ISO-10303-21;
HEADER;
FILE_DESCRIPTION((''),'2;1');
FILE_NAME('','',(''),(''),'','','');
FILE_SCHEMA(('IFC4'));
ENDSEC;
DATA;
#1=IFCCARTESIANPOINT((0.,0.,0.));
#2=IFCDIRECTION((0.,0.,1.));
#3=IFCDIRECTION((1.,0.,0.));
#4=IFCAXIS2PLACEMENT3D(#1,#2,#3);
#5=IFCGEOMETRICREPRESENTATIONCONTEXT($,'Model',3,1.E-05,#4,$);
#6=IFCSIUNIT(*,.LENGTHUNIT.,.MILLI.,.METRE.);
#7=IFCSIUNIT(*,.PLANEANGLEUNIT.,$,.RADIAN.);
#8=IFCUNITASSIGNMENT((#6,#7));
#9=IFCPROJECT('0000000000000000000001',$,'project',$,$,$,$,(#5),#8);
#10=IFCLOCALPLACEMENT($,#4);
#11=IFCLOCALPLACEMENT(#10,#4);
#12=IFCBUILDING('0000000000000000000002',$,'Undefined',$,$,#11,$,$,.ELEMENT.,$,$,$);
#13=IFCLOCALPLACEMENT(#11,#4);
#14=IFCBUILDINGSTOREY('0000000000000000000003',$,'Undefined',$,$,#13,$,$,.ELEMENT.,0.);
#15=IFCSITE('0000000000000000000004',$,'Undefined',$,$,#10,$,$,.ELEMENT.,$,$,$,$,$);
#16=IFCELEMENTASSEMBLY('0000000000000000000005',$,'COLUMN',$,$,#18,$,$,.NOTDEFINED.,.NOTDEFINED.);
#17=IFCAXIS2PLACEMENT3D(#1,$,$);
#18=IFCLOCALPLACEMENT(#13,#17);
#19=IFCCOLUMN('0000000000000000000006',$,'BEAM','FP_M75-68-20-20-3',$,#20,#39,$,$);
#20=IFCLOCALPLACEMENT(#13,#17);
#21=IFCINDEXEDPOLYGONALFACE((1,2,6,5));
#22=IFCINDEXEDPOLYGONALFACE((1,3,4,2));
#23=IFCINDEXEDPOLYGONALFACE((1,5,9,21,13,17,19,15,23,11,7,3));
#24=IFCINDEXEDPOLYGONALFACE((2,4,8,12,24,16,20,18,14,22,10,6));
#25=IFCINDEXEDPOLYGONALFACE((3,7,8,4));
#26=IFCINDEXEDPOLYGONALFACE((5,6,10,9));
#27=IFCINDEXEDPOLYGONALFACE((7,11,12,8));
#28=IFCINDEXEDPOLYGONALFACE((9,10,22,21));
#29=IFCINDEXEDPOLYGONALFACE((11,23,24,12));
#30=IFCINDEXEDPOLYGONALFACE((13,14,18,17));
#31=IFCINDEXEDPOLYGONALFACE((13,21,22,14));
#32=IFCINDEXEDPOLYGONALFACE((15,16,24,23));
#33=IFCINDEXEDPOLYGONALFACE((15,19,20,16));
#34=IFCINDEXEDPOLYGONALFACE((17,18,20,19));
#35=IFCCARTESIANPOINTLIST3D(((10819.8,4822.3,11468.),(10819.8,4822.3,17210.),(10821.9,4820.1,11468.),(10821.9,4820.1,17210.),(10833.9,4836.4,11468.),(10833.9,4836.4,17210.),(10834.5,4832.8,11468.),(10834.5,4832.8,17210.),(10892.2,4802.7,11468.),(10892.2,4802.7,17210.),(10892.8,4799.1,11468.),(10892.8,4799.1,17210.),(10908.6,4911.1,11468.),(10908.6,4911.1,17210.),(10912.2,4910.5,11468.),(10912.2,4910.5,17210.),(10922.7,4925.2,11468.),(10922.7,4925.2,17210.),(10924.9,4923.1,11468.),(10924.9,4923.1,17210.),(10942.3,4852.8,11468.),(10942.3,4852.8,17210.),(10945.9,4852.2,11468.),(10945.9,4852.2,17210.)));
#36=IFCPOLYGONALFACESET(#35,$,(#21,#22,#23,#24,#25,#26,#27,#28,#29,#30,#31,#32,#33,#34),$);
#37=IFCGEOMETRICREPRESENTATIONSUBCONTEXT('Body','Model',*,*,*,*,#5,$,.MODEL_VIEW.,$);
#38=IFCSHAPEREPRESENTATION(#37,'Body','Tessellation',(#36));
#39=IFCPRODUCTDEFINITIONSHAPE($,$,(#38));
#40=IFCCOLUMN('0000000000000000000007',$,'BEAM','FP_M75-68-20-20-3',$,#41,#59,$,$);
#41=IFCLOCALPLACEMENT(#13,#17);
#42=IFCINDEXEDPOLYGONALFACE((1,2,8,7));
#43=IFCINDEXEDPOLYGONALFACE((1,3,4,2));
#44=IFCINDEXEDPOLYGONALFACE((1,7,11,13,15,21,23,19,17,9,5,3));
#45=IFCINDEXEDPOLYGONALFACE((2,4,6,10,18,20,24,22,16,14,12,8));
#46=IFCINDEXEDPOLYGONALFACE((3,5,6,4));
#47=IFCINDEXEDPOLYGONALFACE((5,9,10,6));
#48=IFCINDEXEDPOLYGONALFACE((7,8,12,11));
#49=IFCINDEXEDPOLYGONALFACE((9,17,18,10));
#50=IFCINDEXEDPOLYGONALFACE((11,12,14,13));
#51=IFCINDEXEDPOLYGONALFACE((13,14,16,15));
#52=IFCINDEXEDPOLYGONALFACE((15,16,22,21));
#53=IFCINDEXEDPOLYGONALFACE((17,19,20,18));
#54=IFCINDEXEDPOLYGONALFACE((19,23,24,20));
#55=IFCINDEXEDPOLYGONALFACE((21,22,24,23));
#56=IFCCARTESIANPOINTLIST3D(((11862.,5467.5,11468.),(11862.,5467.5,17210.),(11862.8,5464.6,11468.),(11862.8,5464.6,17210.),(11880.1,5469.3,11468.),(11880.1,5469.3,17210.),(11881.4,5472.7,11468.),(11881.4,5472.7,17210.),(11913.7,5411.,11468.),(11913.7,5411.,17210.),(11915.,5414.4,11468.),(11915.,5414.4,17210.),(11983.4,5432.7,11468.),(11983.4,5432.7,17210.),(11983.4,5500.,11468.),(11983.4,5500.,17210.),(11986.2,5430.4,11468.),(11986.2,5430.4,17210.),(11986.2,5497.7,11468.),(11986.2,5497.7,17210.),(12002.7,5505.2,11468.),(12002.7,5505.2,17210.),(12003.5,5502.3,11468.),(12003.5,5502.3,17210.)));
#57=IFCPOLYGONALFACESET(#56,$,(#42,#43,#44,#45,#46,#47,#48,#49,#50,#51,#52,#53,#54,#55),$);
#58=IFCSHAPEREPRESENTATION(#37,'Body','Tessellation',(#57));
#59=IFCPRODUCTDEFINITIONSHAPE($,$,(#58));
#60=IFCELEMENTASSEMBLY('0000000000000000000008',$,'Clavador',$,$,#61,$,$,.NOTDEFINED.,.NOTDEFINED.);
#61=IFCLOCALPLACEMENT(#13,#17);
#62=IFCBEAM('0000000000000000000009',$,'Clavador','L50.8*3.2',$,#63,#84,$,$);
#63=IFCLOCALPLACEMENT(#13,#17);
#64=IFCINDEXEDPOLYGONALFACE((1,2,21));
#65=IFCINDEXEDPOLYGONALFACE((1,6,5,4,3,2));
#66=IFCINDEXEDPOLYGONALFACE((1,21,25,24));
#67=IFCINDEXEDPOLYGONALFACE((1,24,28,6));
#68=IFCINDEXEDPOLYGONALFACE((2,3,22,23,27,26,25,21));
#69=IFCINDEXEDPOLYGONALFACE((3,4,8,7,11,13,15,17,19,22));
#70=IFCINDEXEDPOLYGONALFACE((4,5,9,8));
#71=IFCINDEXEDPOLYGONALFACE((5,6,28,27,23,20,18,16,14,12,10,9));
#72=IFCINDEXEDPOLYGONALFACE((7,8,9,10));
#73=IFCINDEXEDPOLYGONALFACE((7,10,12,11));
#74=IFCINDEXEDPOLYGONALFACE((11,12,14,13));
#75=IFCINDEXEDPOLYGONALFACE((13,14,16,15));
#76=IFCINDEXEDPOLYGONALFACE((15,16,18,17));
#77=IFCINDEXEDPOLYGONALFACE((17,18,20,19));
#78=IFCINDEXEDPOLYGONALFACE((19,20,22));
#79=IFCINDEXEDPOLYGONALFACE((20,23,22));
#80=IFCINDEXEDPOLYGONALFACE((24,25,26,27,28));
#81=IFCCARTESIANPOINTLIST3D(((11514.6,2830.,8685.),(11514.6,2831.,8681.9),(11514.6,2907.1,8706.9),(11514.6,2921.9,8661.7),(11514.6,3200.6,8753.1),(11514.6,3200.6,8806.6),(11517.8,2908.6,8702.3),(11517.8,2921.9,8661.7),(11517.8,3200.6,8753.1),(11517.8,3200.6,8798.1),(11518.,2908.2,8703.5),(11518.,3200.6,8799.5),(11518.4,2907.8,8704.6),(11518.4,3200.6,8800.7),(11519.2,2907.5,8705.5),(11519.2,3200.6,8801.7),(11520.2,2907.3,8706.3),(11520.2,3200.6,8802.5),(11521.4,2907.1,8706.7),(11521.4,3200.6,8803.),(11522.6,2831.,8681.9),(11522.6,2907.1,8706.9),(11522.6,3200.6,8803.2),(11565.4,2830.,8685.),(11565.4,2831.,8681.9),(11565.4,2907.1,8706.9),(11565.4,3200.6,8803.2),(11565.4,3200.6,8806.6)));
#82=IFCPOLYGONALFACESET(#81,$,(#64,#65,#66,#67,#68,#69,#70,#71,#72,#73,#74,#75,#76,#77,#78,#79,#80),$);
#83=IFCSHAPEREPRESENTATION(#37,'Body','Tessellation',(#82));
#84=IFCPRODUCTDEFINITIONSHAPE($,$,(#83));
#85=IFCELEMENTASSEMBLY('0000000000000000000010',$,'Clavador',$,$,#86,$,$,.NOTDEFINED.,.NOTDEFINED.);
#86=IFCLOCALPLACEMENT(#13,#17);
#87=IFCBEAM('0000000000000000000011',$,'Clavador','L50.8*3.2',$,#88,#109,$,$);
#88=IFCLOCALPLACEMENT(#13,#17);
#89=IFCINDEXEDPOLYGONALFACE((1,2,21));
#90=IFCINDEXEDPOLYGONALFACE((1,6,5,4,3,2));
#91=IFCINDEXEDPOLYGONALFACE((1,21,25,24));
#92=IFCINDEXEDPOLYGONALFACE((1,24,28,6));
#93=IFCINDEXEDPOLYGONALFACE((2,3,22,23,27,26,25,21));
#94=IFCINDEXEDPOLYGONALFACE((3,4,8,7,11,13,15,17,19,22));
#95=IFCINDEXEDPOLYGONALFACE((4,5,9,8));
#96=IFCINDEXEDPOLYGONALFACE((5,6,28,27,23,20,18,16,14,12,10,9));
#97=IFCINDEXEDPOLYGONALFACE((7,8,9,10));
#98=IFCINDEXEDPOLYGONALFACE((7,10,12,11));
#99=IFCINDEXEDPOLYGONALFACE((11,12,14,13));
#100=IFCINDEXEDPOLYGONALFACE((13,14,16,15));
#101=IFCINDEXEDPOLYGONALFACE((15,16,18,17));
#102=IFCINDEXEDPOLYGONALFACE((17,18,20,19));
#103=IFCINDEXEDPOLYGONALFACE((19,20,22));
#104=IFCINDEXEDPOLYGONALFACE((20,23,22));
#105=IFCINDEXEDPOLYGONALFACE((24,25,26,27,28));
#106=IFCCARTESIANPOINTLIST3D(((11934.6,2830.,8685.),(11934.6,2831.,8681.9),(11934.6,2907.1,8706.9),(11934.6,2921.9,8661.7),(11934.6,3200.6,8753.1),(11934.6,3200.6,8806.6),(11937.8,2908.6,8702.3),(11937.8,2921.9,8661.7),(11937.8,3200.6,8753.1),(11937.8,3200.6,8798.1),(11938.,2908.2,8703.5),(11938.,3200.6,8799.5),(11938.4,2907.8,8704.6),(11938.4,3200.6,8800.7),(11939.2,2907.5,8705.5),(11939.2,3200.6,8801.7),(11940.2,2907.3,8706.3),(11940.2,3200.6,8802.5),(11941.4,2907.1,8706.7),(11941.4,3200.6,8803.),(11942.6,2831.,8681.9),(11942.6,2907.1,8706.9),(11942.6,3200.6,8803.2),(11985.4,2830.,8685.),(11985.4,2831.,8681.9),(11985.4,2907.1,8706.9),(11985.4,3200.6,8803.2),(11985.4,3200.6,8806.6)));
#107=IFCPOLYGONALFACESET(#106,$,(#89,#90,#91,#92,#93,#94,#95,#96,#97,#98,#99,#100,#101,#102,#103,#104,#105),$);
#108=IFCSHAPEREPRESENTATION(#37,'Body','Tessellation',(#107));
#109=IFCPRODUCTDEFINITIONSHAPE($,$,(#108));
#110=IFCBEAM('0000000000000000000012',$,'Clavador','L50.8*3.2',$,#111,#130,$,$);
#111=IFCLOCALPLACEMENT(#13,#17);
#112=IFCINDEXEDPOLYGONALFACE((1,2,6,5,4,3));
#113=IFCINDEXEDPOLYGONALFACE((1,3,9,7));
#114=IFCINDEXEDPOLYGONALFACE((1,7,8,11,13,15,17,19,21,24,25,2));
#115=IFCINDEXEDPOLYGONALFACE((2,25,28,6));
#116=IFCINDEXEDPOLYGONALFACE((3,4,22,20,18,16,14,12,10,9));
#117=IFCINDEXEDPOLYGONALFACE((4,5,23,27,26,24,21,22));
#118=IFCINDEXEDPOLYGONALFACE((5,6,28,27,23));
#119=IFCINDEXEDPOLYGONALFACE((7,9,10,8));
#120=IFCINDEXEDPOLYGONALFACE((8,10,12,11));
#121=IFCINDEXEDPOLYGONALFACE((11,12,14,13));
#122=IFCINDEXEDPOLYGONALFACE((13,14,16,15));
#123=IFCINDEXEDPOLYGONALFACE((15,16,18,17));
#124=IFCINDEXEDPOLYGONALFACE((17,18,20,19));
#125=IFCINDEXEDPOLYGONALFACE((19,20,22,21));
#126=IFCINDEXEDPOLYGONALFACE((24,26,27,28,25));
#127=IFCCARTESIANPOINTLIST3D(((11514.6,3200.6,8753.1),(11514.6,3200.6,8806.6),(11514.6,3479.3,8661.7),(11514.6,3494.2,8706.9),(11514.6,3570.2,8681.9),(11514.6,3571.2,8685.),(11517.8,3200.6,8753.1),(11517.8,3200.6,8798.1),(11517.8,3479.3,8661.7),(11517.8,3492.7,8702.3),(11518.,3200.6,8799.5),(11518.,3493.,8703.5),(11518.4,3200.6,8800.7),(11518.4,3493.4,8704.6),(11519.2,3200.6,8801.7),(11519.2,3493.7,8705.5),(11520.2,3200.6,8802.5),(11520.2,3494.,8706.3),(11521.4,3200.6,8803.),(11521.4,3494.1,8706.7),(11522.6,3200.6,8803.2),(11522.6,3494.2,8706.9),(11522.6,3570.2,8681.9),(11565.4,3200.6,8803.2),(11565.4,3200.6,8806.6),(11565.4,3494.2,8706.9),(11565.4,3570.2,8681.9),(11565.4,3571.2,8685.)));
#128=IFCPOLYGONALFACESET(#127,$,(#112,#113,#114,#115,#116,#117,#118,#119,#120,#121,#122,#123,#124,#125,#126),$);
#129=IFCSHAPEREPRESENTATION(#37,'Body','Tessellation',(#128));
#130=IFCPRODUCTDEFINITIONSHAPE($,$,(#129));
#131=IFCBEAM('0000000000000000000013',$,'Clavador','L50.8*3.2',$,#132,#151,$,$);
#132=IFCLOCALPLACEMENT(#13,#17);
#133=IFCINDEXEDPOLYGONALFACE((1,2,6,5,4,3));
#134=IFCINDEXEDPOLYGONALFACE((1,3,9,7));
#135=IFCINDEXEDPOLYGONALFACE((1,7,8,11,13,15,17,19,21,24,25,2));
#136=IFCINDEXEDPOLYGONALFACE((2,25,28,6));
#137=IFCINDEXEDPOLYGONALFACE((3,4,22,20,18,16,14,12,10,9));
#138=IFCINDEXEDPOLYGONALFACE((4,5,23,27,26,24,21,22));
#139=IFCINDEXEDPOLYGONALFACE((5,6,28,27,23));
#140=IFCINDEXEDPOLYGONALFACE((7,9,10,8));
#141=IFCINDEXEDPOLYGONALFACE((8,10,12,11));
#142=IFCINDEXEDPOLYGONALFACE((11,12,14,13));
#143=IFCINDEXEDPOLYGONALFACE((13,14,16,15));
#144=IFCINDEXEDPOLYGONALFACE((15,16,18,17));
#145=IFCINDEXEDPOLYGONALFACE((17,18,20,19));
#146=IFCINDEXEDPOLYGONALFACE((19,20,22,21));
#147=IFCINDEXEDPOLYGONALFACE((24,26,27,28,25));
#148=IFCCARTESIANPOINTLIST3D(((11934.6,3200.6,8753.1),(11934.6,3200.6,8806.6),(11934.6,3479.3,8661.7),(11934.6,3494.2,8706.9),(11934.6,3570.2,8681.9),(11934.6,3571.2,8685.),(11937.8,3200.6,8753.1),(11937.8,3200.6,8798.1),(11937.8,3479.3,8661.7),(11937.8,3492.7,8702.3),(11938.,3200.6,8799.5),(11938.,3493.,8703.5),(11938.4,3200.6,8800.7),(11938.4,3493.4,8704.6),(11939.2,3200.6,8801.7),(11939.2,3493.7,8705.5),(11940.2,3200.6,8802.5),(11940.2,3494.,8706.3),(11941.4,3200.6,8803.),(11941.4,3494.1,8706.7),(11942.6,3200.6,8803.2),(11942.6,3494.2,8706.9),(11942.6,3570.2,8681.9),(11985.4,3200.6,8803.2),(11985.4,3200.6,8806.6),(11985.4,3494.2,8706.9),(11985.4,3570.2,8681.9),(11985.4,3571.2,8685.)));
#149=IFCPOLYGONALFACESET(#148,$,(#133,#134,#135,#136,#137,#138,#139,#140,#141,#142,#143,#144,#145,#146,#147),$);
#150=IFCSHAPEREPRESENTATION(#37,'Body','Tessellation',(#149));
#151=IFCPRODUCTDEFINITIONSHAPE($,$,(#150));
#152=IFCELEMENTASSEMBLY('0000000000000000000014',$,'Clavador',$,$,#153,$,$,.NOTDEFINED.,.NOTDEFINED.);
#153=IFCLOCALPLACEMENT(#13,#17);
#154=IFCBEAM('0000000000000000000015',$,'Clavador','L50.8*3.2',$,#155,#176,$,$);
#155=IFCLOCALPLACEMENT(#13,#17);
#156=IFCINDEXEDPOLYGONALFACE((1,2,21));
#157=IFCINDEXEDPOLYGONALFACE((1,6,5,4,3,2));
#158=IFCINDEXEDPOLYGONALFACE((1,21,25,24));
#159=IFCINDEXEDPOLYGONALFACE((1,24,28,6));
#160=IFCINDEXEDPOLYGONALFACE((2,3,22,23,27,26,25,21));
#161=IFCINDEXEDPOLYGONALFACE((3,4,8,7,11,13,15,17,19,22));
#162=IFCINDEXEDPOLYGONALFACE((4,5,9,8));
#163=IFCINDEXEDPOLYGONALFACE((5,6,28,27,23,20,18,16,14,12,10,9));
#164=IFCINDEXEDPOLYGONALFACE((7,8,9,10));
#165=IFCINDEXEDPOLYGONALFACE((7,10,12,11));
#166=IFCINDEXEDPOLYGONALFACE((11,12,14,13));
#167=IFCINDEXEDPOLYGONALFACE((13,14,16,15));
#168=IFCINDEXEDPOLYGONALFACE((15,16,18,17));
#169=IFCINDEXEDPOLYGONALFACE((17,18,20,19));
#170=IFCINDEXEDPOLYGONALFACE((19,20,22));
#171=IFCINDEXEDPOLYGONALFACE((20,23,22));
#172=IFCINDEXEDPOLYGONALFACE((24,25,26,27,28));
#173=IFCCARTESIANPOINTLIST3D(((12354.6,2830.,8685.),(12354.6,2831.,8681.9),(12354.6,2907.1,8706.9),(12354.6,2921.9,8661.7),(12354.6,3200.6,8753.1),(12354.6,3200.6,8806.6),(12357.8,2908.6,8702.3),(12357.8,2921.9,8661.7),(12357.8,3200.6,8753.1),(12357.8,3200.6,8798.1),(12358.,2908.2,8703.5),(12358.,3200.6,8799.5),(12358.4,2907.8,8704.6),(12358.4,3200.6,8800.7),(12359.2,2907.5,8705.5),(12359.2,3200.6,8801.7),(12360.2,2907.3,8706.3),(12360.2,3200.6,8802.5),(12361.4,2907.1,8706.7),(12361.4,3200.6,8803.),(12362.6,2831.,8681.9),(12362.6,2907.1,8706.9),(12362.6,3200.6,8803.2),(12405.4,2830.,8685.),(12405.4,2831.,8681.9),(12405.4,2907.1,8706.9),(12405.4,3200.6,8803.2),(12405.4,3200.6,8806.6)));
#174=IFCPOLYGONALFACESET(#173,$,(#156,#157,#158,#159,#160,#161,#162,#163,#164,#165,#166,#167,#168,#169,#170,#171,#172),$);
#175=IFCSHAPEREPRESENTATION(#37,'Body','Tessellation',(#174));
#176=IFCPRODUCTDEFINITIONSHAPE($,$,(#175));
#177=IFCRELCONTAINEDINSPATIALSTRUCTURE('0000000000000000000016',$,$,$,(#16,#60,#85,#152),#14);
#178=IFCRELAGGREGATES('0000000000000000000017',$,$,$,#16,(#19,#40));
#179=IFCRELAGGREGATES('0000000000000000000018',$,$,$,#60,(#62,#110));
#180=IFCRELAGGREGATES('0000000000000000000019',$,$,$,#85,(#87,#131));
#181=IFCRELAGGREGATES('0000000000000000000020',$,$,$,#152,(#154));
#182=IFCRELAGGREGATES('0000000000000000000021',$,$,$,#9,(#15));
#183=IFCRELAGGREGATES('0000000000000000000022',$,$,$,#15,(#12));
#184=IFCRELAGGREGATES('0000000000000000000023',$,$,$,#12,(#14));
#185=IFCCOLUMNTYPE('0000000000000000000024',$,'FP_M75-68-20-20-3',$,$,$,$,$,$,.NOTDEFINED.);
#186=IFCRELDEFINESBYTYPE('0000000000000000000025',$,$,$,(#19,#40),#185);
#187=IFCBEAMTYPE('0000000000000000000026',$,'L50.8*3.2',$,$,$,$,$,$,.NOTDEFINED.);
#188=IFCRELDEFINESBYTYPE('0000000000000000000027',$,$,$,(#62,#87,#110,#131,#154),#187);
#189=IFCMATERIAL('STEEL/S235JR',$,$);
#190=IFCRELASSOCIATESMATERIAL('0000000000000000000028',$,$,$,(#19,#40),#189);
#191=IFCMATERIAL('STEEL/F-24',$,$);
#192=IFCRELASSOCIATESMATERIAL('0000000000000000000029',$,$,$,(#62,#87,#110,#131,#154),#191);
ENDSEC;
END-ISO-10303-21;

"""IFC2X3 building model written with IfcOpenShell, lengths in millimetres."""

from ifc_helpers import new_model, si_unit, frame, origin_with_axes, origin_2d_with_axis, place, context, subcontext, project, spatial, polyline, l_section, outline, extrude, boolean, halfspace, material, type_object, element, aggregate, save


model = new_model("IFC2X3")

# Units and contexts
model_context = context("Model", 3, precision=1e-05, world=origin_with_axes())
body_context = subcontext(model_context, "Body", "Model", "MODEL_VIEW")
ifc_project = project(units=[si_unit("LENGTHUNIT", "METRE", prefix="MILLI"), si_unit("PLANEANGLEUNIT", "RADIAN")], contexts=[model_context])

# Site, building, storey
site_placement = place(None, origin_with_axes())
site = spatial("IfcSite", under=ifc_project, at=site_placement, Name="Undefined", CompositionType="ELEMENT")
building_placement = place(site_placement, origin_with_axes())
building = spatial("IfcBuilding", under=site, at=building_placement, Name="Undefined", CompositionType="ELEMENT")
storey_placement = place(building_placement, origin_with_axes())
storey = spatial("IfcBuildingStorey", under=building, at=storey_placement, Name="Undefined", CompositionType="ELEMENT", Elevation=0.0)

# Element assembly, columns
assembly_1_placement = place(storey_placement, origin_with_axes())
assembly_1 = element("IfcElementAssembly", 1, at=assembly_1_placement, inside=storey, Name="COLUMN", AssemblyPlace="NOTDEFINED", PredefinedType="NOTDEFINED")
ifc_material_1 = material(Name="STEEL/S235JR")
column_type = type_object("IfcColumnType", Name="FP_M75-68-20-20-3", PredefinedType="NOTDEFINED")
column_1_placement = place(assembly_1_placement, frame((10895.3, 4849.7, 11468.0), z_axis=(0.0, 0.0, 1.0), x_axis=(0.707107, 0.707107, 0.0)))
column_1 = element("IfcColumn", 2, at=column_1_placement, type_object=column_type, material=ifc_material_1, Name="BEAM", Description="FP_M75-68-20-20-3", context=body_context, shape_type="SweptSolid", body=[
    extrude(outline(polyline([(31.0, 54.9), (31.0, 72.8), (34.0, 72.8), (34.0, 52.8), (-31.0, 35.4), (-31.0, -35.4), (34.0, -52.8), (34.0, -72.8), (31.0, -72.8), (31.0, -54.9), (-34.0, -37.5), (-34.0, 37.5), (31.0, 54.9)])), frame((0.0, 0.0, 5742.0), z_axis=(0.0, 0.0, -1.0), x_axis=(0.0, 1.0, 0.0)), (0.0, 0.0, 1.0), 5742.0),
])
column_2_placement = place(assembly_1_placement, frame((11941.2, 5453.5, 11468.0), z_axis=(0.0, 0.0, 1.0), x_axis=(0.965926, 0.258819, 0.0)))
column_2 = element("IfcColumn", 3, at=column_2_placement, type_object=column_type, material=ifc_material_1, Name="BEAM", Description="FP_M75-68-20-20-3", context=body_context, shape_type="SweptSolid", body=[
    extrude(outline(polyline([(31.0, 54.9), (31.0, 72.8), (34.0, 72.8), (34.0, 52.8), (-31.0, 35.4), (-31.0, -35.4), (34.0, -52.8), (34.0, -72.8), (31.0, -72.8), (31.0, -54.9), (-34.0, -37.5), (-34.0, 37.5), (31.0, 54.9)])), frame((0.0, 0.0, 5742.0), z_axis=(0.0, 0.0, -1.0), x_axis=(0.0, 1.0, 0.0)), (0.0, 0.0, 1.0), 5742.0),
])
aggregate(assembly_1, [column_1, column_2])

# Element assemblies, beams
assembly_2_placement = place(storey_placement, origin_with_axes())
assembly_2 = element("IfcElementAssembly", 4, at=assembly_2_placement, inside=storey, Name="Clavador", AssemblyPlace="NOTDEFINED", PredefinedType="NOTDEFINED")
ifc_material_2 = material(Name="STEEL/F-24")
beam_type_1 = type_object("IfcBeamType", Name="L50.8*3.2", PredefinedType="NOTDEFINED")
beam_1_placement = place(assembly_2_placement, frame((11540.0, 3208.5, 8782.4), z_axis=(0.0, 0.311771, -0.950157), x_axis=(0.0, -0.950157, -0.311771)))
beam_1 = element("IfcBeam", 5, at=beam_1_placement, type_object=beam_type_1, material=ifc_material_2, Name="Clavador", Description="L50.8*3.2", context=body_context, shape_type="CSG", body=[
    boolean("DIFFERENCE", boolean("DIFFERENCE", extrude(l_section(Depth=50.8, Width=50.8, Thickness=3.2, FilletRadius=4.8, at=origin_2d_with_axis()), frame((390.0, 0.0, 0.0), z_axis=(-1.0, 0.0, 0.0), x_axis=(0.0, -1.0, 0.0)), (0.0, 0.0, 1.0), 397.4), extrude(outline(polyline([(0.0, 0.0), (47.6, 0.0), (47.6, 80.0), (0.0, 80.0), (0.0, 0.0)])), frame((390.0, 28.0, -22.2), z_axis=(0.0, -1.0, 0.0), x_axis=(0.0, 0.0, 1.0)), (0.0, 0.0, 1.0), 56.0)), halfspace(frame((0.0, 0.0, -25.4), z_axis=(-0.950157, 0.0, 0.311771), x_axis=(0.0, 1.0, 0.0)), False)),
])
assembly_3_placement = place(storey_placement, origin_with_axes())
assembly_3 = element("IfcElementAssembly", 6, at=assembly_3_placement, inside=storey, Name="Clavador", AssemblyPlace="NOTDEFINED", PredefinedType="NOTDEFINED")
beam_2_placement = place(assembly_3_placement, frame((11960.0, 3208.5, 8782.4), z_axis=(0.0, 0.311771, -0.950157), x_axis=(0.0, -0.950157, -0.311771)))
beam_2 = element("IfcBeam", 7, at=beam_2_placement, type_object=beam_type_1, material=ifc_material_2, Name="Clavador", Description="L50.8*3.2", context=body_context, shape_type="CSG", body=[
    boolean("DIFFERENCE", boolean("DIFFERENCE", extrude(l_section(Depth=50.8, Width=50.8, Thickness=3.2, FilletRadius=4.8, at=origin_2d_with_axis()), frame((390.0, 0.0, 0.0), z_axis=(-1.0, 0.0, 0.0), x_axis=(0.0, -1.0, 0.0)), (0.0, 0.0, 1.0), 397.4), extrude(outline(polyline([(0.0, 0.0), (47.6, 0.0), (47.6, 80.0), (0.0, 80.0), (0.0, 0.0)])), frame((390.0, 28.0, -22.2), z_axis=(0.0, -1.0, 0.0), x_axis=(0.0, 0.0, 1.0)), (0.0, 0.0, 1.0), 56.0)), halfspace(frame((0.0, 0.0, -25.4), z_axis=(-0.950157, 0.0, 0.311771), x_axis=(0.0, 1.0, 0.0)), False)),
])

# Beams
beam_3_placement = place(assembly_2_placement, frame((11540.0, 3563.2, 8660.8), z_axis=(0.0, -0.311771, -0.950157), x_axis=(0.0, -0.950157, 0.311771)))
beam_3 = element("IfcBeam", 8, at=beam_3_placement, type_object=beam_type_1, material=ifc_material_2, Name="Clavador", Description="L50.8*3.2", context=body_context, shape_type="CSG", body=[
    boolean("DIFFERENCE", boolean("DIFFERENCE", extrude(l_section(Depth=50.8, Width=50.8, Thickness=3.2, FilletRadius=4.8, at=origin_2d_with_axis()), frame((397.4, 0.0, 0.0), z_axis=(-1.0, 0.0, 0.0), x_axis=(0.0, -1.0, 0.0)), (0.0, 0.0, 1.0), 397.4), extrude(outline(polyline([(0.0, 0.0), (47.6, 0.0), (47.6, 80.0), (0.0, 80.0), (0.0, 0.0)])), frame((0.0, -28.0, -22.2), z_axis=(0.0, 1.0, 0.0), x_axis=(0.0, 0.0, 1.0)), (0.0, 0.0, 1.0), 56.0)), halfspace(frame((390.0, 0.0, -25.4), z_axis=(-0.950157, 0.0, -0.311771), x_axis=(0.0, 1.0, 0.0)), True)),
])
aggregate(assembly_2, [beam_1, beam_3])
beam_4_placement = place(assembly_3_placement, frame((11960.0, 3563.2, 8660.8), z_axis=(0.0, -0.311771, -0.950157), x_axis=(0.0, -0.950157, 0.311771)))
beam_4 = element("IfcBeam", 9, at=beam_4_placement, type_object=beam_type_1, material=ifc_material_2, Name="Clavador", Description="L50.8*3.2", context=body_context, shape_type="CSG", body=[
    boolean("DIFFERENCE", boolean("DIFFERENCE", extrude(l_section(Depth=50.8, Width=50.8, Thickness=3.2, FilletRadius=4.8, at=origin_2d_with_axis()), frame((397.4, 0.0, 0.0), z_axis=(-1.0, 0.0, 0.0), x_axis=(0.0, -1.0, 0.0)), (0.0, 0.0, 1.0), 397.4), extrude(outline(polyline([(0.0, 0.0), (47.6, 0.0), (47.6, 80.0), (0.0, 80.0), (0.0, 0.0)])), frame((0.0, -28.0, -22.2), z_axis=(0.0, 1.0, 0.0), x_axis=(0.0, 0.0, 1.0)), (0.0, 0.0, 1.0), 56.0)), halfspace(frame((390.0, 0.0, -25.4), z_axis=(-0.950157, 0.0, -0.311771), x_axis=(0.0, 1.0, 0.0)), True)),
])
aggregate(assembly_3, [beam_2, beam_4])

# Element assembly, beam
assembly_4_placement = place(storey_placement, origin_with_axes())
assembly_4 = element("IfcElementAssembly", 10, at=assembly_4_placement, inside=storey, Name="Clavador", AssemblyPlace="NOTDEFINED", PredefinedType="NOTDEFINED")
beam_5_placement = place(assembly_4_placement, frame((12380.0, 3208.5, 8782.4), z_axis=(0.0, 0.311771, -0.950157), x_axis=(0.0, -0.950157, -0.311771)))
beam_5 = element("IfcBeam", 11, at=beam_5_placement, type_object=beam_type_1, material=ifc_material_2, Name="Clavador", Description="L50.8*3.2", context=body_context, shape_type="CSG", body=[
    boolean("DIFFERENCE", boolean("DIFFERENCE", extrude(l_section(Depth=50.8, Width=50.8, Thickness=3.2, FilletRadius=4.8, at=origin_2d_with_axis()), frame((390.0, 0.0, 0.0), z_axis=(-1.0, 0.0, 0.0), x_axis=(0.0, -1.0, 0.0)), (0.0, 0.0, 1.0), 397.4), extrude(outline(polyline([(0.0, 0.0), (47.6, 0.0), (47.6, 80.0), (0.0, 80.0), (0.0, 0.0)])), frame((390.0, 28.0, -22.2), z_axis=(0.0, -1.0, 0.0), x_axis=(0.0, 0.0, 1.0)), (0.0, 0.0, 1.0), 56.0)), halfspace(frame((0.0, 0.0, -25.4), z_axis=(-0.950157, 0.0, 0.311771), x_axis=(0.0, 1.0, 0.0)), False)),
])
aggregate(assembly_4, [beam_5])

save(model, "model.ifc")
